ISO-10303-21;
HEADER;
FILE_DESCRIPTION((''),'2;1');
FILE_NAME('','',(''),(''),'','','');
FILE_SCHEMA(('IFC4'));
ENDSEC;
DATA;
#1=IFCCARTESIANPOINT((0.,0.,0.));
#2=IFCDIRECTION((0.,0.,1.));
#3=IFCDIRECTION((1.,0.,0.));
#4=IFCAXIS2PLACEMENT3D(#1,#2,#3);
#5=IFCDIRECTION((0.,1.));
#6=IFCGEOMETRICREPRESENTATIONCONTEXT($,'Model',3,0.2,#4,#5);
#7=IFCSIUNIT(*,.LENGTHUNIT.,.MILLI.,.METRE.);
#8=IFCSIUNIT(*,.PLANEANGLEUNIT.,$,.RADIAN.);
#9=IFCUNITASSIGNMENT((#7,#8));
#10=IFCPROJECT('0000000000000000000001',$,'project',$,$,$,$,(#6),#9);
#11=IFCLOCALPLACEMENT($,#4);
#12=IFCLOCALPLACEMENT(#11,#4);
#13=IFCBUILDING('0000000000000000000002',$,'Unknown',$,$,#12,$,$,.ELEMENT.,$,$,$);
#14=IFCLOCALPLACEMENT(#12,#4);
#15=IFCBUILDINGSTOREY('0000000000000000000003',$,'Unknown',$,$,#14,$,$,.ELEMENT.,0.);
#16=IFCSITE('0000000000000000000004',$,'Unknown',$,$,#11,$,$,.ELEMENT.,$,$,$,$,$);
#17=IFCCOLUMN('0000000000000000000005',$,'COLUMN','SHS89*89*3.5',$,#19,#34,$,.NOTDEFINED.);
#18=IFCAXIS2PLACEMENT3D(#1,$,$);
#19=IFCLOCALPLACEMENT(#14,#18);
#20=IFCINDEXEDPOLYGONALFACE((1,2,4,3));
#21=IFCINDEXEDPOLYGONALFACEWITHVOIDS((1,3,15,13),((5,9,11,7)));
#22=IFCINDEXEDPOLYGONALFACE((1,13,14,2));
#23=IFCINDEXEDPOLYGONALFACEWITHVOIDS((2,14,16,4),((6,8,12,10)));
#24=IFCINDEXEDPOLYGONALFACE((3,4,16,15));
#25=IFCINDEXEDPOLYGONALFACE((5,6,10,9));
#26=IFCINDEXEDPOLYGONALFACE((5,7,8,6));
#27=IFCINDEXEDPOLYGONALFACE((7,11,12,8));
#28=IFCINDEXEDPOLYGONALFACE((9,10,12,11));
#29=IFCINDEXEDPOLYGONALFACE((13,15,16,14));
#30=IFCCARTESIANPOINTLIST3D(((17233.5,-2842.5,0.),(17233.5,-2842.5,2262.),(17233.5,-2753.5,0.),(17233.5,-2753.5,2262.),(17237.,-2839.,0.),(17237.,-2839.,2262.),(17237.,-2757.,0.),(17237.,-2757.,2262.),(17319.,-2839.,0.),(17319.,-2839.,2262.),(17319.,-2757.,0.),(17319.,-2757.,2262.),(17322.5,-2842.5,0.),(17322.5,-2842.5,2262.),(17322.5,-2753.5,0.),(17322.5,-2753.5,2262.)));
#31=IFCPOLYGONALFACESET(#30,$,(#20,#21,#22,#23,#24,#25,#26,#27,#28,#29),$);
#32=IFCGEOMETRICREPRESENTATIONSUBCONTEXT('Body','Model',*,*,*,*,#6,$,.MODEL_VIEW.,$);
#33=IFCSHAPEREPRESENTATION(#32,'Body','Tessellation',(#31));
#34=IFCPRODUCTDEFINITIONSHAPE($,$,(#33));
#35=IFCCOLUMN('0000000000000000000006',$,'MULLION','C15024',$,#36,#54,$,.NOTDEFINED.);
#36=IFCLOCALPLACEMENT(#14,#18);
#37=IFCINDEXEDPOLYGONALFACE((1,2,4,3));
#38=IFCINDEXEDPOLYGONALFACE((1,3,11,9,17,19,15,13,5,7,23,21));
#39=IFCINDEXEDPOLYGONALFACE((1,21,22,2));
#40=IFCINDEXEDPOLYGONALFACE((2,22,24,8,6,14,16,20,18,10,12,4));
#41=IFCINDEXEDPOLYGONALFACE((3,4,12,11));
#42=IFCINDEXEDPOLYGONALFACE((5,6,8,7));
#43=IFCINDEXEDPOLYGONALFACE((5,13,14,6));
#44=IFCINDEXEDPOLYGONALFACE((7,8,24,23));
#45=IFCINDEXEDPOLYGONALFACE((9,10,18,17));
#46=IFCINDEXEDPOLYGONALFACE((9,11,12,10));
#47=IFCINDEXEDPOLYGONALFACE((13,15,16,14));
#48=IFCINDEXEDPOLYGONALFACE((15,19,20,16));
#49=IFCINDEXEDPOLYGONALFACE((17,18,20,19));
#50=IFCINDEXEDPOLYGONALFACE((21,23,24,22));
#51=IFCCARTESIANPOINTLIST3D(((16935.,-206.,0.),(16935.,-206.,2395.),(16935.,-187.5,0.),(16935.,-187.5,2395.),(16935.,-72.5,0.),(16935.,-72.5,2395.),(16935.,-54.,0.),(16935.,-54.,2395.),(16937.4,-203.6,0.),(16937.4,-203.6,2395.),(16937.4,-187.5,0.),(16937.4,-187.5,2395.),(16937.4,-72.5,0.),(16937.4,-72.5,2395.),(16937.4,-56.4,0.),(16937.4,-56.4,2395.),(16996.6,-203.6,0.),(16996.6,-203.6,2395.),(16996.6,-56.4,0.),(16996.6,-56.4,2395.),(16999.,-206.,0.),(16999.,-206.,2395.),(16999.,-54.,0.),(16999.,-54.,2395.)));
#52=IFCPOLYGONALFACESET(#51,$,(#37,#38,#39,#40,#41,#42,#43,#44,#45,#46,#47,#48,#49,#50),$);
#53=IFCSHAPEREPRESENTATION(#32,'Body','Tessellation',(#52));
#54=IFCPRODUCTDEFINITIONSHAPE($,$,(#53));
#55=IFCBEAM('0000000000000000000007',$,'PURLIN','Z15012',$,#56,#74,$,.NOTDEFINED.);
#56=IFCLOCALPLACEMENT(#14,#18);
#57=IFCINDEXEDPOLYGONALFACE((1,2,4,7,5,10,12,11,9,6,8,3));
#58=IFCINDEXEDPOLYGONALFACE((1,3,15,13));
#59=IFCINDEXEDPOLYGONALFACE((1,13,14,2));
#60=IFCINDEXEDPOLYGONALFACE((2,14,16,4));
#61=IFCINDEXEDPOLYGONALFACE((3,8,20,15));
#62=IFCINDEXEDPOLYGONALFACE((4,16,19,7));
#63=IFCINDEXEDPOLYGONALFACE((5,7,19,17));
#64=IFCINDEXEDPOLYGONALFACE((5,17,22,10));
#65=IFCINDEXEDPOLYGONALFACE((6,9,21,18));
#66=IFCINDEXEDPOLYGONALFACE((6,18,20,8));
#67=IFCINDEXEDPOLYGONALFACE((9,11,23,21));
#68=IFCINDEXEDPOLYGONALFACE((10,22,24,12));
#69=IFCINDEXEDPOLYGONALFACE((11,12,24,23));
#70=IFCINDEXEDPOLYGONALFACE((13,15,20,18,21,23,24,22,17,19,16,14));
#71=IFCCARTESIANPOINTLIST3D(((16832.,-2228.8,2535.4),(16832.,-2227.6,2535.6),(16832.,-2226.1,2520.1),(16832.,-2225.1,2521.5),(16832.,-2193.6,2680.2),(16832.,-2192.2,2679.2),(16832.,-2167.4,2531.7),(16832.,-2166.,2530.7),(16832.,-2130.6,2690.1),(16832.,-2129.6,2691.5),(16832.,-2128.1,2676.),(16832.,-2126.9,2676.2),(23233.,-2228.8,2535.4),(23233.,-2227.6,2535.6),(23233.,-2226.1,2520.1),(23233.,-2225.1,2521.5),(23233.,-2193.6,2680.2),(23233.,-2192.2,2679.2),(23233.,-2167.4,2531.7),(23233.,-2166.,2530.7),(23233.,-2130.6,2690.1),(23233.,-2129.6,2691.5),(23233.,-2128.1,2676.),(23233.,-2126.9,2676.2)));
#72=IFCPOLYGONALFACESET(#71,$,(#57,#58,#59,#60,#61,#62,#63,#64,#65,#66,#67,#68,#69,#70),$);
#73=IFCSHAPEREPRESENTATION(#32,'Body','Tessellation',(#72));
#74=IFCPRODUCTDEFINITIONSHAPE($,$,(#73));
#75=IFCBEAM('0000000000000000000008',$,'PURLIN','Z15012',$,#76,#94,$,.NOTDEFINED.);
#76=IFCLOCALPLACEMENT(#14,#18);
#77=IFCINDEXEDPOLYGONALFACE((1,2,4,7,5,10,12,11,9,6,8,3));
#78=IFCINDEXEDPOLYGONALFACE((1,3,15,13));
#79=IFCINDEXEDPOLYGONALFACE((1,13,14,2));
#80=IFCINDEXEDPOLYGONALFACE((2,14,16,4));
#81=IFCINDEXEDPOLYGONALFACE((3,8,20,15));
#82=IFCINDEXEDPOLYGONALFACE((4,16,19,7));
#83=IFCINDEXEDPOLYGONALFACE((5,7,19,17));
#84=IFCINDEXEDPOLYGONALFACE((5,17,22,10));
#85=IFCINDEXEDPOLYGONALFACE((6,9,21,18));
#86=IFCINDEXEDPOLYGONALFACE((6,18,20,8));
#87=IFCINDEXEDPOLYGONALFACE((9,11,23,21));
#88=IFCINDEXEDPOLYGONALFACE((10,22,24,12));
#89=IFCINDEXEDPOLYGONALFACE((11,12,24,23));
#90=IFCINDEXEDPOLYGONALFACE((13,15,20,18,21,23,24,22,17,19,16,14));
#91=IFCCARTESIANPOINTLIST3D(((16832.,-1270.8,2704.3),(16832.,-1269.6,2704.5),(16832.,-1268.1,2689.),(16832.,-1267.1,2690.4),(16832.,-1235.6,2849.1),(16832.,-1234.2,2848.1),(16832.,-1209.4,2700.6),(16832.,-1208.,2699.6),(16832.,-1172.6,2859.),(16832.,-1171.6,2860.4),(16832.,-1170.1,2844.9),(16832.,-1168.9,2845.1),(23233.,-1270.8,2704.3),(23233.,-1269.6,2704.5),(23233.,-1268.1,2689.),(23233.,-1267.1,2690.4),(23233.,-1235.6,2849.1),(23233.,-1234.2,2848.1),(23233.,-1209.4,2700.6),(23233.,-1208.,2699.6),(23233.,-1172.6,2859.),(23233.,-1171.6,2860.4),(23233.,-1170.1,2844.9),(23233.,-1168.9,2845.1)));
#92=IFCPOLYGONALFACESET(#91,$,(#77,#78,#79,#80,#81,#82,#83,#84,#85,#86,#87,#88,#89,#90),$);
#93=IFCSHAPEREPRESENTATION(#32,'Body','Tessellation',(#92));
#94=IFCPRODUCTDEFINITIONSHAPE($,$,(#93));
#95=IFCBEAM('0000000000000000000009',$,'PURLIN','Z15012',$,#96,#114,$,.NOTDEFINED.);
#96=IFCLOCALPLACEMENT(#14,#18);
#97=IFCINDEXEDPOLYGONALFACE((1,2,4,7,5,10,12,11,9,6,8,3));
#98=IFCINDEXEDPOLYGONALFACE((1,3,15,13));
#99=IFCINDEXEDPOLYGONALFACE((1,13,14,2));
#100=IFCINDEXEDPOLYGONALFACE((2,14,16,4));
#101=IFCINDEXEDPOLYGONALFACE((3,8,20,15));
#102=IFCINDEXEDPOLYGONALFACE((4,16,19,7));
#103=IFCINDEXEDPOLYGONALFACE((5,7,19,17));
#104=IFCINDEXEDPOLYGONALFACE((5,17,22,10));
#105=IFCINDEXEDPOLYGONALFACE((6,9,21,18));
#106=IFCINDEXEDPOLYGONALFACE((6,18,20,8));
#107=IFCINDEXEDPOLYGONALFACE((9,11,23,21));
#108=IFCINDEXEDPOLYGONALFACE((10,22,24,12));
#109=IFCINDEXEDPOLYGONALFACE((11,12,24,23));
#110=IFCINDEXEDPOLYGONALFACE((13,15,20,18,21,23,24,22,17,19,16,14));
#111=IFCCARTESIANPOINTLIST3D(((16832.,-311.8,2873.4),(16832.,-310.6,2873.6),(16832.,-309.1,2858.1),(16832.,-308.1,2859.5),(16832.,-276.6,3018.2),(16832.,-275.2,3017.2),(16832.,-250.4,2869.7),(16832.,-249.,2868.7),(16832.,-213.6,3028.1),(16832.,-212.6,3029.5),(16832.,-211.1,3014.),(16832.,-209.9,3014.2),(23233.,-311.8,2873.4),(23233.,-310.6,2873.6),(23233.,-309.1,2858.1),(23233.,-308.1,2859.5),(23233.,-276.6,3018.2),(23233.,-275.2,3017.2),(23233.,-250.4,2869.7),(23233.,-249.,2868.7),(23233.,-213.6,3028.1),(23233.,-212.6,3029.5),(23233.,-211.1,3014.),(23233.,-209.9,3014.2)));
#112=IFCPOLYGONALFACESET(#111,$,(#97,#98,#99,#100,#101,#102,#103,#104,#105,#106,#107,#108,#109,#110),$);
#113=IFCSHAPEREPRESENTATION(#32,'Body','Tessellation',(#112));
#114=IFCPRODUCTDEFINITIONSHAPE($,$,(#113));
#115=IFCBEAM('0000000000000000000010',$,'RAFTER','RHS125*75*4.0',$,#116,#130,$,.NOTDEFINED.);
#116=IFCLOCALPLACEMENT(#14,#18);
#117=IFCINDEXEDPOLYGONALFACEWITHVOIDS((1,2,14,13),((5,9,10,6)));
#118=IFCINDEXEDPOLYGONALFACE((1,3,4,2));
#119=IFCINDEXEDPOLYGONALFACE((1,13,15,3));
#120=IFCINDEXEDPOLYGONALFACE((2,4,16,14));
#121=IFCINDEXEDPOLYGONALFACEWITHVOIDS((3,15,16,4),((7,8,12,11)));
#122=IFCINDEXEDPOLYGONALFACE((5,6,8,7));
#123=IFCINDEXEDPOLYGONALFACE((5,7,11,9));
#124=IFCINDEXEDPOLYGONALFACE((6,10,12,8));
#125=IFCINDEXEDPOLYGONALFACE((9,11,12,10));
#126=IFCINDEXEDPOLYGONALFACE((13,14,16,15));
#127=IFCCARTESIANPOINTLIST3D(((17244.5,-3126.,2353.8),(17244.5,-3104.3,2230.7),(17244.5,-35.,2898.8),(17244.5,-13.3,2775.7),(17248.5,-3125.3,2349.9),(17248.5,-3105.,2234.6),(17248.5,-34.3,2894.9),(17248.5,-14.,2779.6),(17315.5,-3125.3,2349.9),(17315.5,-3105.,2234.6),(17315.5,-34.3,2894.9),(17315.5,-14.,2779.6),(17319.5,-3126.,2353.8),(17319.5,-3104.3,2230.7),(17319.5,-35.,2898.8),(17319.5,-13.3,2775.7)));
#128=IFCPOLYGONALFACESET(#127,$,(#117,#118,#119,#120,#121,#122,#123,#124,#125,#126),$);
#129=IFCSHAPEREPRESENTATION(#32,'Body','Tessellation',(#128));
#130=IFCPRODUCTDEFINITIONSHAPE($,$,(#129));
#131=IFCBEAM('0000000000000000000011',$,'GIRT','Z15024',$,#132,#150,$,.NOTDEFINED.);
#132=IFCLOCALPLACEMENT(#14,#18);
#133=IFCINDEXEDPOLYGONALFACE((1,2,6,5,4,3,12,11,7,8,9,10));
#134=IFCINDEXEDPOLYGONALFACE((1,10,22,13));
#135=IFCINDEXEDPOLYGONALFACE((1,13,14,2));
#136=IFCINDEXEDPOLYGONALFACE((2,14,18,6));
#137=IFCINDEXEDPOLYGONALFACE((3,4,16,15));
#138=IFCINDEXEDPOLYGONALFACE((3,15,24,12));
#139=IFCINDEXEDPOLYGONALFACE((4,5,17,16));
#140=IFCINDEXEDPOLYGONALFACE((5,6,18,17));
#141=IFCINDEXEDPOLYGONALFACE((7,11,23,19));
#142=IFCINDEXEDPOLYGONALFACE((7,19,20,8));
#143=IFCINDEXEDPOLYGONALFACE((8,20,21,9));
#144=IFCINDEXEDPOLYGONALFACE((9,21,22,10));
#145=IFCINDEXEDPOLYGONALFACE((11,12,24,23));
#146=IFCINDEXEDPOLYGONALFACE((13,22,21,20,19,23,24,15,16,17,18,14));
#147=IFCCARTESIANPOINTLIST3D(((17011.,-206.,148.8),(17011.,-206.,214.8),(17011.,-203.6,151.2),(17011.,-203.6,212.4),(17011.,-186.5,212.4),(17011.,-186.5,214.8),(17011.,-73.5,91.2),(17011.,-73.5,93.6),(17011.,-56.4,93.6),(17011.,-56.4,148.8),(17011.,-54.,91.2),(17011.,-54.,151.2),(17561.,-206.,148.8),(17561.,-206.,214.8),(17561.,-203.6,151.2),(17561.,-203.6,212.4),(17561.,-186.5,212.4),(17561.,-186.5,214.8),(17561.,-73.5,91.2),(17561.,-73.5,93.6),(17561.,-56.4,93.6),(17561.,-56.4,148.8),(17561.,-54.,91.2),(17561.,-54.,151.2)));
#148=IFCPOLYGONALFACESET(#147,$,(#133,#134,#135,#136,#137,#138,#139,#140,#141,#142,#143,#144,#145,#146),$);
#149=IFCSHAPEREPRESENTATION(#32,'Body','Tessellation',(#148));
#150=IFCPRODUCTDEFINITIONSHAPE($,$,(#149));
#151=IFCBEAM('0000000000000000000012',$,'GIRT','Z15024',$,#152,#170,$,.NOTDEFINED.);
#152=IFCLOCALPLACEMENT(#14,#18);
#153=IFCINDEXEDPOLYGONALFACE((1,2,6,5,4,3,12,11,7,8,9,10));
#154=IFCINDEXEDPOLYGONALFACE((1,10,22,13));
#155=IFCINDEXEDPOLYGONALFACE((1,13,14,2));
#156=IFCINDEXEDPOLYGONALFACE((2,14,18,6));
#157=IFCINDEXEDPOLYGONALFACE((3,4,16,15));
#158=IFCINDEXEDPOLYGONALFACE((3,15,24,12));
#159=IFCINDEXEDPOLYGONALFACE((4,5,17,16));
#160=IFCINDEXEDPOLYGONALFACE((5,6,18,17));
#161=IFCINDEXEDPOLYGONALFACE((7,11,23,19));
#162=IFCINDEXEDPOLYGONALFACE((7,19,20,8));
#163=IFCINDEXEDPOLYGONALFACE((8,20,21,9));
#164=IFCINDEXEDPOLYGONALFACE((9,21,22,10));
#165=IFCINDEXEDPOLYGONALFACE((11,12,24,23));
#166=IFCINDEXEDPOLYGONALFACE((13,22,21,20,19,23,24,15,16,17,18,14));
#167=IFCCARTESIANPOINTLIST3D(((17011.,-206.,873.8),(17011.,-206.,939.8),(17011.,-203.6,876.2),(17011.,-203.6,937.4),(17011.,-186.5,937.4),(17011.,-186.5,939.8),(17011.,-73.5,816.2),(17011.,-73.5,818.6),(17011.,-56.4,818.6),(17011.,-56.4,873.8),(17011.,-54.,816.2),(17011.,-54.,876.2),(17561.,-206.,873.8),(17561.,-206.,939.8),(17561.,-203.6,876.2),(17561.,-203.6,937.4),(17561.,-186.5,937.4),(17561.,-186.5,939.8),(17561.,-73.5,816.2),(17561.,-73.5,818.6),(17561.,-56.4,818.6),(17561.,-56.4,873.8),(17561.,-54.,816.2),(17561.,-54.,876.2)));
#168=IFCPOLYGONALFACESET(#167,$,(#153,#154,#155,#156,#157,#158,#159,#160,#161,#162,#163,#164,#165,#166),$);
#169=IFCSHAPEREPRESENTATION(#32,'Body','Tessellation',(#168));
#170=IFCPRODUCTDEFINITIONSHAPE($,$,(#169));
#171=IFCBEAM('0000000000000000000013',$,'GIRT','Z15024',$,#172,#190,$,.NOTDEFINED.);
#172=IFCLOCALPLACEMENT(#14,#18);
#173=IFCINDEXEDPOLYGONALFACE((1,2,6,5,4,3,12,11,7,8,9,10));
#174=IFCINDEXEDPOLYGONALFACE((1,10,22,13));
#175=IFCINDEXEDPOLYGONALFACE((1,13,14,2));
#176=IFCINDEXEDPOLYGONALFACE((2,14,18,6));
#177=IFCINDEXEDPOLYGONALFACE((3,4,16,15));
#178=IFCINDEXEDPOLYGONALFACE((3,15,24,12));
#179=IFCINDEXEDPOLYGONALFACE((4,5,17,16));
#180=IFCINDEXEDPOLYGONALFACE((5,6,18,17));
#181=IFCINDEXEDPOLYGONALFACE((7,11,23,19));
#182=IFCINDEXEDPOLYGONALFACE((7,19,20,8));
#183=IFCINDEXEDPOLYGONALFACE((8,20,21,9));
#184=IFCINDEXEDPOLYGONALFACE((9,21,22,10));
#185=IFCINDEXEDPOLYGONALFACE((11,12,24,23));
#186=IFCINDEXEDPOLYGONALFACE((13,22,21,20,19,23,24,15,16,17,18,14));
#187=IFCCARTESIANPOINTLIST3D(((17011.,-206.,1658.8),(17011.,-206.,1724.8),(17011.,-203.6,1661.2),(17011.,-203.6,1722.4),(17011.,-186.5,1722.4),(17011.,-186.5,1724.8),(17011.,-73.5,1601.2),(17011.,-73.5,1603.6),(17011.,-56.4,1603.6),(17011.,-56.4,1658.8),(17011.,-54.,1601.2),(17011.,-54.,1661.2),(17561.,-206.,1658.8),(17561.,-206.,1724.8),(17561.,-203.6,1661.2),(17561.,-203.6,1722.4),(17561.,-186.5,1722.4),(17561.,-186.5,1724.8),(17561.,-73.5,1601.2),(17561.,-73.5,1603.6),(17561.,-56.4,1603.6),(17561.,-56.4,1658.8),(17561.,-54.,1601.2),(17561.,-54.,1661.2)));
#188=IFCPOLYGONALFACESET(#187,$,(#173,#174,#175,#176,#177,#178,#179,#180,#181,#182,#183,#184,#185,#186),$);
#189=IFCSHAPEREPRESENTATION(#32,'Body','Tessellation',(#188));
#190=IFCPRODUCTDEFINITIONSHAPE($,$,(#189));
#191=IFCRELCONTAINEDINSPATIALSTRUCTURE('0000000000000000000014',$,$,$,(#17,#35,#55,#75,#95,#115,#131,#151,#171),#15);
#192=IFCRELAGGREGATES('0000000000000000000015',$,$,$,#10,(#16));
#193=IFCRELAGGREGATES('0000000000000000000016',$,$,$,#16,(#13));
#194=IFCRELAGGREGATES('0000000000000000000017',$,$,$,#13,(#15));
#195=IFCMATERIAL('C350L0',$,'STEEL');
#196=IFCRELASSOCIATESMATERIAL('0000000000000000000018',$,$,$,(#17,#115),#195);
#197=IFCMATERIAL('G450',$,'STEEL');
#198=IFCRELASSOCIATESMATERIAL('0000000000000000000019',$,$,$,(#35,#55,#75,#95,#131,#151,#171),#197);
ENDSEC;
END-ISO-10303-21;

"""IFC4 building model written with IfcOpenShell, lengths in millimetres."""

from ifc_helpers import new_model, si_unit, direction, frame, origin_with_axes, place, context, subcontext, project, spatial, line, indexed_curve, outline, extrude, material, element, save


model = new_model("IFC4")

# Units and contexts
model_context = context("Model", 3, precision=0.2, world=origin_with_axes(), true_north=direction((0.0, 1.0)))
body_context = subcontext(model_context, "Body", "Model", "MODEL_VIEW")
ifc_project = project(units=[si_unit("LENGTHUNIT", "METRE", prefix="MILLI"), si_unit("PLANEANGLEUNIT", "RADIAN")], contexts=[model_context])

# Site, building, storey
site_placement = place(None, origin_with_axes())
site = spatial("IfcSite", under=ifc_project, at=site_placement, Name="Unknown", CompositionType="ELEMENT")
building_placement = place(site_placement, origin_with_axes())
building = spatial("IfcBuilding", under=site, at=building_placement, Name="Unknown", CompositionType="ELEMENT")
storey_placement = place(building_placement, origin_with_axes())
storey = spatial("IfcBuildingStorey", under=building, at=storey_placement, Name="Unknown", CompositionType="ELEMENT", Elevation=0.0)

# Columns
ifc_material_1 = material(Name="C350L0", Category="STEEL")
column_1_placement = place(storey_placement, frame((17278.0, -2798.0, 0.0), z_axis=(-1.0, 0.0, 0.0), x_axis=(0.0, 0.0, 1.0)))
element("IfcColumn", 1, at=column_1_placement, inside=storey, material=ifc_material_1, Name="COLUMN", Description="SHS89*89*3.5", PredefinedType="NOTDEFINED", context=body_context, shape_type="SolidModel", body=[
    extrude(outline(indexed_curve([(-44.5, -44.5), (44.5, -44.5), (44.5, 44.5), (-44.5, 44.5)], segments=[line(1, 2, 3, 4, 1)]), holes=[indexed_curve([(-41.0, -41.0), (-41.0, 41.0), (41.0, 41.0), (41.0, -41.0)], segments=[line(1, 2, 3, 4, 1)])]), frame((0.0, 0.0, 0.0), z_axis=(-1.0, 0.0, 0.0), x_axis=(0.0, 0.0, 1.0)), (0.0, 0.0, -1.0), 2262.0),
])
ifc_material_2 = material(Name="G450", Category="STEEL")
column_2_placement = place(storey_placement, frame((16967.0, -130.0, 0.0), z_axis=(-1.0, 0.0, 0.0), x_axis=(0.0, 0.0, 1.0)))
element("IfcColumn", 2, at=column_2_placement, inside=storey, material=ifc_material_2, Name="MULLION", Description="C15024", PredefinedType="NOTDEFINED", context=body_context, shape_type="SolidModel", body=[
    extrude(outline(indexed_curve([(32.0, -76.0), (32.0, -57.5), (29.6, -57.5), (29.6, -73.6), (-29.6, -73.6), (-29.6, 73.6), (29.6, 73.6), (29.6, 57.5), (32.0, 57.5), (32.0, 76.0), (-32.0, 76.0), (-32.0, -76.0)], segments=[line(1, 2, 3, 4, 5, 6, 7, 8, 9, 10, 11, 12, 1)])), frame((0.0, 0.0, 0.0), z_axis=(-1.0, 0.0, 0.0), x_axis=(0.0, 0.0, 1.0)), (0.0, 0.0, -1.0), 2395.0),
])

# Beams
for number, where, z_axis, x_axis, name in (
    (3, (16832.0, -2179.8, 2605.5), (0.0, -0.984808, -0.173648), (1.0, 0.0, 0.0), "PURLIN"),
    (4, (16832.0, -1221.8, 2774.4), (0.0, -0.984808, -0.173648), (1.0, 0.0, 0.0), "PURLIN"),
    (5, (16832.0, -262.8, 2943.5), (0.0, -0.984808, -0.173648), (1.0, 0.0, 0.0), "PURLIN"),
):
    element("IfcBeam", number, at=place(storey_placement, frame(where, z_axis=z_axis, x_axis=x_axis)), inside=storey, material=ifc_material_2, Name=name, Description="Z15012", PredefinedType="NOTDEFINED", context=body_context, shape_type="SolidModel", body=[
        extrude(outline(indexed_curve([(60.4, -76.0), (60.4, -60.5), (59.2, -60.5), (59.2, -74.8), (0.6, -74.8), (0.6, 76.0), (-64.4, 76.0), (-64.4, 60.5), (-63.2, 60.5), (-63.2, 74.8), (-0.6, 74.8), (-0.6, -76.0)], segments=[line(1, 2, 3, 4, 5, 6, 7, 8, 9, 10, 11, 12, 1)])), frame((0.0, 0.0, 0.0), z_axis=(-1.0, 0.0, 0.0), x_axis=(0.0, 0.0, 1.0)), (0.0, 0.0, -1.0), 6401.0),
    ])
beam_1_placement = place(storey_placement, frame((17282.0, -24.1, 2837.2), z_axis=(-1.0, 0.0, 0.0), x_axis=(0.0, -0.984809, -0.17364)))
element("IfcBeam", 6, at=beam_1_placement, inside=storey, material=ifc_material_1, Name="RAFTER", Description="RHS125*75*4.0", PredefinedType="NOTDEFINED", context=body_context, shape_type="SolidModel", body=[
    extrude(outline(indexed_curve([(-37.5, -62.5), (37.5, -62.5), (37.5, 62.5), (-37.5, 62.5)], segments=[line(1, 2, 3, 4, 1)]), holes=[indexed_curve([(-33.5, -58.5), (-33.5, 58.5), (33.5, 58.5), (33.5, -58.5)], segments=[line(1, 2, 3, 4, 1)])]), frame((0.0, 0.0, 0.0), z_axis=(-1.0, 0.0, 0.0), x_axis=(0.0, 0.0, 1.0)), (0.0, 0.0, -1.0), 3138.7),
])
for number, where, z_axis, x_axis, name in (
    (7, (17011.0, -130.0, 150.0), (0.0, 0.0, -1.0), (1.0, 0.0, 0.0), "GIRT"),
    (8, (17011.0, -130.0, 875.0), (0.0, 0.0, -1.0), (1.0, 0.0, 0.0), "GIRT"),
    (9, (17011.0, -130.0, 1660.0), (0.0, 0.0, -1.0), (1.0, 0.0, 0.0), "GIRT"),
):
    element("IfcBeam", number, at=place(storey_placement, frame(where, z_axis=z_axis, x_axis=x_axis)), inside=storey, material=ifc_material_2, Name=name, Description="Z15024", PredefinedType="NOTDEFINED", context=body_context, shape_type="SolidModel", body=[
        extrude(outline(indexed_curve([(58.8, -76.0), (58.8, -56.5), (56.4, -56.5), (56.4, -73.6), (1.2, -73.6), (1.2, 76.0), (-64.8, 76.0), (-64.8, 56.5), (-62.4, 56.5), (-62.4, 73.6), (-1.2, 73.6), (-1.2, -76.0)], segments=[line(1, 2, 3, 4, 5, 6, 7, 8, 9, 10, 11, 12, 1)])), frame((0.0, 0.0, 0.0), z_axis=(-1.0, 0.0, 0.0), x_axis=(0.0, 0.0, 1.0)), (0.0, 0.0, -1.0), 550.0),
    ])

save(model, "model.ifc")
